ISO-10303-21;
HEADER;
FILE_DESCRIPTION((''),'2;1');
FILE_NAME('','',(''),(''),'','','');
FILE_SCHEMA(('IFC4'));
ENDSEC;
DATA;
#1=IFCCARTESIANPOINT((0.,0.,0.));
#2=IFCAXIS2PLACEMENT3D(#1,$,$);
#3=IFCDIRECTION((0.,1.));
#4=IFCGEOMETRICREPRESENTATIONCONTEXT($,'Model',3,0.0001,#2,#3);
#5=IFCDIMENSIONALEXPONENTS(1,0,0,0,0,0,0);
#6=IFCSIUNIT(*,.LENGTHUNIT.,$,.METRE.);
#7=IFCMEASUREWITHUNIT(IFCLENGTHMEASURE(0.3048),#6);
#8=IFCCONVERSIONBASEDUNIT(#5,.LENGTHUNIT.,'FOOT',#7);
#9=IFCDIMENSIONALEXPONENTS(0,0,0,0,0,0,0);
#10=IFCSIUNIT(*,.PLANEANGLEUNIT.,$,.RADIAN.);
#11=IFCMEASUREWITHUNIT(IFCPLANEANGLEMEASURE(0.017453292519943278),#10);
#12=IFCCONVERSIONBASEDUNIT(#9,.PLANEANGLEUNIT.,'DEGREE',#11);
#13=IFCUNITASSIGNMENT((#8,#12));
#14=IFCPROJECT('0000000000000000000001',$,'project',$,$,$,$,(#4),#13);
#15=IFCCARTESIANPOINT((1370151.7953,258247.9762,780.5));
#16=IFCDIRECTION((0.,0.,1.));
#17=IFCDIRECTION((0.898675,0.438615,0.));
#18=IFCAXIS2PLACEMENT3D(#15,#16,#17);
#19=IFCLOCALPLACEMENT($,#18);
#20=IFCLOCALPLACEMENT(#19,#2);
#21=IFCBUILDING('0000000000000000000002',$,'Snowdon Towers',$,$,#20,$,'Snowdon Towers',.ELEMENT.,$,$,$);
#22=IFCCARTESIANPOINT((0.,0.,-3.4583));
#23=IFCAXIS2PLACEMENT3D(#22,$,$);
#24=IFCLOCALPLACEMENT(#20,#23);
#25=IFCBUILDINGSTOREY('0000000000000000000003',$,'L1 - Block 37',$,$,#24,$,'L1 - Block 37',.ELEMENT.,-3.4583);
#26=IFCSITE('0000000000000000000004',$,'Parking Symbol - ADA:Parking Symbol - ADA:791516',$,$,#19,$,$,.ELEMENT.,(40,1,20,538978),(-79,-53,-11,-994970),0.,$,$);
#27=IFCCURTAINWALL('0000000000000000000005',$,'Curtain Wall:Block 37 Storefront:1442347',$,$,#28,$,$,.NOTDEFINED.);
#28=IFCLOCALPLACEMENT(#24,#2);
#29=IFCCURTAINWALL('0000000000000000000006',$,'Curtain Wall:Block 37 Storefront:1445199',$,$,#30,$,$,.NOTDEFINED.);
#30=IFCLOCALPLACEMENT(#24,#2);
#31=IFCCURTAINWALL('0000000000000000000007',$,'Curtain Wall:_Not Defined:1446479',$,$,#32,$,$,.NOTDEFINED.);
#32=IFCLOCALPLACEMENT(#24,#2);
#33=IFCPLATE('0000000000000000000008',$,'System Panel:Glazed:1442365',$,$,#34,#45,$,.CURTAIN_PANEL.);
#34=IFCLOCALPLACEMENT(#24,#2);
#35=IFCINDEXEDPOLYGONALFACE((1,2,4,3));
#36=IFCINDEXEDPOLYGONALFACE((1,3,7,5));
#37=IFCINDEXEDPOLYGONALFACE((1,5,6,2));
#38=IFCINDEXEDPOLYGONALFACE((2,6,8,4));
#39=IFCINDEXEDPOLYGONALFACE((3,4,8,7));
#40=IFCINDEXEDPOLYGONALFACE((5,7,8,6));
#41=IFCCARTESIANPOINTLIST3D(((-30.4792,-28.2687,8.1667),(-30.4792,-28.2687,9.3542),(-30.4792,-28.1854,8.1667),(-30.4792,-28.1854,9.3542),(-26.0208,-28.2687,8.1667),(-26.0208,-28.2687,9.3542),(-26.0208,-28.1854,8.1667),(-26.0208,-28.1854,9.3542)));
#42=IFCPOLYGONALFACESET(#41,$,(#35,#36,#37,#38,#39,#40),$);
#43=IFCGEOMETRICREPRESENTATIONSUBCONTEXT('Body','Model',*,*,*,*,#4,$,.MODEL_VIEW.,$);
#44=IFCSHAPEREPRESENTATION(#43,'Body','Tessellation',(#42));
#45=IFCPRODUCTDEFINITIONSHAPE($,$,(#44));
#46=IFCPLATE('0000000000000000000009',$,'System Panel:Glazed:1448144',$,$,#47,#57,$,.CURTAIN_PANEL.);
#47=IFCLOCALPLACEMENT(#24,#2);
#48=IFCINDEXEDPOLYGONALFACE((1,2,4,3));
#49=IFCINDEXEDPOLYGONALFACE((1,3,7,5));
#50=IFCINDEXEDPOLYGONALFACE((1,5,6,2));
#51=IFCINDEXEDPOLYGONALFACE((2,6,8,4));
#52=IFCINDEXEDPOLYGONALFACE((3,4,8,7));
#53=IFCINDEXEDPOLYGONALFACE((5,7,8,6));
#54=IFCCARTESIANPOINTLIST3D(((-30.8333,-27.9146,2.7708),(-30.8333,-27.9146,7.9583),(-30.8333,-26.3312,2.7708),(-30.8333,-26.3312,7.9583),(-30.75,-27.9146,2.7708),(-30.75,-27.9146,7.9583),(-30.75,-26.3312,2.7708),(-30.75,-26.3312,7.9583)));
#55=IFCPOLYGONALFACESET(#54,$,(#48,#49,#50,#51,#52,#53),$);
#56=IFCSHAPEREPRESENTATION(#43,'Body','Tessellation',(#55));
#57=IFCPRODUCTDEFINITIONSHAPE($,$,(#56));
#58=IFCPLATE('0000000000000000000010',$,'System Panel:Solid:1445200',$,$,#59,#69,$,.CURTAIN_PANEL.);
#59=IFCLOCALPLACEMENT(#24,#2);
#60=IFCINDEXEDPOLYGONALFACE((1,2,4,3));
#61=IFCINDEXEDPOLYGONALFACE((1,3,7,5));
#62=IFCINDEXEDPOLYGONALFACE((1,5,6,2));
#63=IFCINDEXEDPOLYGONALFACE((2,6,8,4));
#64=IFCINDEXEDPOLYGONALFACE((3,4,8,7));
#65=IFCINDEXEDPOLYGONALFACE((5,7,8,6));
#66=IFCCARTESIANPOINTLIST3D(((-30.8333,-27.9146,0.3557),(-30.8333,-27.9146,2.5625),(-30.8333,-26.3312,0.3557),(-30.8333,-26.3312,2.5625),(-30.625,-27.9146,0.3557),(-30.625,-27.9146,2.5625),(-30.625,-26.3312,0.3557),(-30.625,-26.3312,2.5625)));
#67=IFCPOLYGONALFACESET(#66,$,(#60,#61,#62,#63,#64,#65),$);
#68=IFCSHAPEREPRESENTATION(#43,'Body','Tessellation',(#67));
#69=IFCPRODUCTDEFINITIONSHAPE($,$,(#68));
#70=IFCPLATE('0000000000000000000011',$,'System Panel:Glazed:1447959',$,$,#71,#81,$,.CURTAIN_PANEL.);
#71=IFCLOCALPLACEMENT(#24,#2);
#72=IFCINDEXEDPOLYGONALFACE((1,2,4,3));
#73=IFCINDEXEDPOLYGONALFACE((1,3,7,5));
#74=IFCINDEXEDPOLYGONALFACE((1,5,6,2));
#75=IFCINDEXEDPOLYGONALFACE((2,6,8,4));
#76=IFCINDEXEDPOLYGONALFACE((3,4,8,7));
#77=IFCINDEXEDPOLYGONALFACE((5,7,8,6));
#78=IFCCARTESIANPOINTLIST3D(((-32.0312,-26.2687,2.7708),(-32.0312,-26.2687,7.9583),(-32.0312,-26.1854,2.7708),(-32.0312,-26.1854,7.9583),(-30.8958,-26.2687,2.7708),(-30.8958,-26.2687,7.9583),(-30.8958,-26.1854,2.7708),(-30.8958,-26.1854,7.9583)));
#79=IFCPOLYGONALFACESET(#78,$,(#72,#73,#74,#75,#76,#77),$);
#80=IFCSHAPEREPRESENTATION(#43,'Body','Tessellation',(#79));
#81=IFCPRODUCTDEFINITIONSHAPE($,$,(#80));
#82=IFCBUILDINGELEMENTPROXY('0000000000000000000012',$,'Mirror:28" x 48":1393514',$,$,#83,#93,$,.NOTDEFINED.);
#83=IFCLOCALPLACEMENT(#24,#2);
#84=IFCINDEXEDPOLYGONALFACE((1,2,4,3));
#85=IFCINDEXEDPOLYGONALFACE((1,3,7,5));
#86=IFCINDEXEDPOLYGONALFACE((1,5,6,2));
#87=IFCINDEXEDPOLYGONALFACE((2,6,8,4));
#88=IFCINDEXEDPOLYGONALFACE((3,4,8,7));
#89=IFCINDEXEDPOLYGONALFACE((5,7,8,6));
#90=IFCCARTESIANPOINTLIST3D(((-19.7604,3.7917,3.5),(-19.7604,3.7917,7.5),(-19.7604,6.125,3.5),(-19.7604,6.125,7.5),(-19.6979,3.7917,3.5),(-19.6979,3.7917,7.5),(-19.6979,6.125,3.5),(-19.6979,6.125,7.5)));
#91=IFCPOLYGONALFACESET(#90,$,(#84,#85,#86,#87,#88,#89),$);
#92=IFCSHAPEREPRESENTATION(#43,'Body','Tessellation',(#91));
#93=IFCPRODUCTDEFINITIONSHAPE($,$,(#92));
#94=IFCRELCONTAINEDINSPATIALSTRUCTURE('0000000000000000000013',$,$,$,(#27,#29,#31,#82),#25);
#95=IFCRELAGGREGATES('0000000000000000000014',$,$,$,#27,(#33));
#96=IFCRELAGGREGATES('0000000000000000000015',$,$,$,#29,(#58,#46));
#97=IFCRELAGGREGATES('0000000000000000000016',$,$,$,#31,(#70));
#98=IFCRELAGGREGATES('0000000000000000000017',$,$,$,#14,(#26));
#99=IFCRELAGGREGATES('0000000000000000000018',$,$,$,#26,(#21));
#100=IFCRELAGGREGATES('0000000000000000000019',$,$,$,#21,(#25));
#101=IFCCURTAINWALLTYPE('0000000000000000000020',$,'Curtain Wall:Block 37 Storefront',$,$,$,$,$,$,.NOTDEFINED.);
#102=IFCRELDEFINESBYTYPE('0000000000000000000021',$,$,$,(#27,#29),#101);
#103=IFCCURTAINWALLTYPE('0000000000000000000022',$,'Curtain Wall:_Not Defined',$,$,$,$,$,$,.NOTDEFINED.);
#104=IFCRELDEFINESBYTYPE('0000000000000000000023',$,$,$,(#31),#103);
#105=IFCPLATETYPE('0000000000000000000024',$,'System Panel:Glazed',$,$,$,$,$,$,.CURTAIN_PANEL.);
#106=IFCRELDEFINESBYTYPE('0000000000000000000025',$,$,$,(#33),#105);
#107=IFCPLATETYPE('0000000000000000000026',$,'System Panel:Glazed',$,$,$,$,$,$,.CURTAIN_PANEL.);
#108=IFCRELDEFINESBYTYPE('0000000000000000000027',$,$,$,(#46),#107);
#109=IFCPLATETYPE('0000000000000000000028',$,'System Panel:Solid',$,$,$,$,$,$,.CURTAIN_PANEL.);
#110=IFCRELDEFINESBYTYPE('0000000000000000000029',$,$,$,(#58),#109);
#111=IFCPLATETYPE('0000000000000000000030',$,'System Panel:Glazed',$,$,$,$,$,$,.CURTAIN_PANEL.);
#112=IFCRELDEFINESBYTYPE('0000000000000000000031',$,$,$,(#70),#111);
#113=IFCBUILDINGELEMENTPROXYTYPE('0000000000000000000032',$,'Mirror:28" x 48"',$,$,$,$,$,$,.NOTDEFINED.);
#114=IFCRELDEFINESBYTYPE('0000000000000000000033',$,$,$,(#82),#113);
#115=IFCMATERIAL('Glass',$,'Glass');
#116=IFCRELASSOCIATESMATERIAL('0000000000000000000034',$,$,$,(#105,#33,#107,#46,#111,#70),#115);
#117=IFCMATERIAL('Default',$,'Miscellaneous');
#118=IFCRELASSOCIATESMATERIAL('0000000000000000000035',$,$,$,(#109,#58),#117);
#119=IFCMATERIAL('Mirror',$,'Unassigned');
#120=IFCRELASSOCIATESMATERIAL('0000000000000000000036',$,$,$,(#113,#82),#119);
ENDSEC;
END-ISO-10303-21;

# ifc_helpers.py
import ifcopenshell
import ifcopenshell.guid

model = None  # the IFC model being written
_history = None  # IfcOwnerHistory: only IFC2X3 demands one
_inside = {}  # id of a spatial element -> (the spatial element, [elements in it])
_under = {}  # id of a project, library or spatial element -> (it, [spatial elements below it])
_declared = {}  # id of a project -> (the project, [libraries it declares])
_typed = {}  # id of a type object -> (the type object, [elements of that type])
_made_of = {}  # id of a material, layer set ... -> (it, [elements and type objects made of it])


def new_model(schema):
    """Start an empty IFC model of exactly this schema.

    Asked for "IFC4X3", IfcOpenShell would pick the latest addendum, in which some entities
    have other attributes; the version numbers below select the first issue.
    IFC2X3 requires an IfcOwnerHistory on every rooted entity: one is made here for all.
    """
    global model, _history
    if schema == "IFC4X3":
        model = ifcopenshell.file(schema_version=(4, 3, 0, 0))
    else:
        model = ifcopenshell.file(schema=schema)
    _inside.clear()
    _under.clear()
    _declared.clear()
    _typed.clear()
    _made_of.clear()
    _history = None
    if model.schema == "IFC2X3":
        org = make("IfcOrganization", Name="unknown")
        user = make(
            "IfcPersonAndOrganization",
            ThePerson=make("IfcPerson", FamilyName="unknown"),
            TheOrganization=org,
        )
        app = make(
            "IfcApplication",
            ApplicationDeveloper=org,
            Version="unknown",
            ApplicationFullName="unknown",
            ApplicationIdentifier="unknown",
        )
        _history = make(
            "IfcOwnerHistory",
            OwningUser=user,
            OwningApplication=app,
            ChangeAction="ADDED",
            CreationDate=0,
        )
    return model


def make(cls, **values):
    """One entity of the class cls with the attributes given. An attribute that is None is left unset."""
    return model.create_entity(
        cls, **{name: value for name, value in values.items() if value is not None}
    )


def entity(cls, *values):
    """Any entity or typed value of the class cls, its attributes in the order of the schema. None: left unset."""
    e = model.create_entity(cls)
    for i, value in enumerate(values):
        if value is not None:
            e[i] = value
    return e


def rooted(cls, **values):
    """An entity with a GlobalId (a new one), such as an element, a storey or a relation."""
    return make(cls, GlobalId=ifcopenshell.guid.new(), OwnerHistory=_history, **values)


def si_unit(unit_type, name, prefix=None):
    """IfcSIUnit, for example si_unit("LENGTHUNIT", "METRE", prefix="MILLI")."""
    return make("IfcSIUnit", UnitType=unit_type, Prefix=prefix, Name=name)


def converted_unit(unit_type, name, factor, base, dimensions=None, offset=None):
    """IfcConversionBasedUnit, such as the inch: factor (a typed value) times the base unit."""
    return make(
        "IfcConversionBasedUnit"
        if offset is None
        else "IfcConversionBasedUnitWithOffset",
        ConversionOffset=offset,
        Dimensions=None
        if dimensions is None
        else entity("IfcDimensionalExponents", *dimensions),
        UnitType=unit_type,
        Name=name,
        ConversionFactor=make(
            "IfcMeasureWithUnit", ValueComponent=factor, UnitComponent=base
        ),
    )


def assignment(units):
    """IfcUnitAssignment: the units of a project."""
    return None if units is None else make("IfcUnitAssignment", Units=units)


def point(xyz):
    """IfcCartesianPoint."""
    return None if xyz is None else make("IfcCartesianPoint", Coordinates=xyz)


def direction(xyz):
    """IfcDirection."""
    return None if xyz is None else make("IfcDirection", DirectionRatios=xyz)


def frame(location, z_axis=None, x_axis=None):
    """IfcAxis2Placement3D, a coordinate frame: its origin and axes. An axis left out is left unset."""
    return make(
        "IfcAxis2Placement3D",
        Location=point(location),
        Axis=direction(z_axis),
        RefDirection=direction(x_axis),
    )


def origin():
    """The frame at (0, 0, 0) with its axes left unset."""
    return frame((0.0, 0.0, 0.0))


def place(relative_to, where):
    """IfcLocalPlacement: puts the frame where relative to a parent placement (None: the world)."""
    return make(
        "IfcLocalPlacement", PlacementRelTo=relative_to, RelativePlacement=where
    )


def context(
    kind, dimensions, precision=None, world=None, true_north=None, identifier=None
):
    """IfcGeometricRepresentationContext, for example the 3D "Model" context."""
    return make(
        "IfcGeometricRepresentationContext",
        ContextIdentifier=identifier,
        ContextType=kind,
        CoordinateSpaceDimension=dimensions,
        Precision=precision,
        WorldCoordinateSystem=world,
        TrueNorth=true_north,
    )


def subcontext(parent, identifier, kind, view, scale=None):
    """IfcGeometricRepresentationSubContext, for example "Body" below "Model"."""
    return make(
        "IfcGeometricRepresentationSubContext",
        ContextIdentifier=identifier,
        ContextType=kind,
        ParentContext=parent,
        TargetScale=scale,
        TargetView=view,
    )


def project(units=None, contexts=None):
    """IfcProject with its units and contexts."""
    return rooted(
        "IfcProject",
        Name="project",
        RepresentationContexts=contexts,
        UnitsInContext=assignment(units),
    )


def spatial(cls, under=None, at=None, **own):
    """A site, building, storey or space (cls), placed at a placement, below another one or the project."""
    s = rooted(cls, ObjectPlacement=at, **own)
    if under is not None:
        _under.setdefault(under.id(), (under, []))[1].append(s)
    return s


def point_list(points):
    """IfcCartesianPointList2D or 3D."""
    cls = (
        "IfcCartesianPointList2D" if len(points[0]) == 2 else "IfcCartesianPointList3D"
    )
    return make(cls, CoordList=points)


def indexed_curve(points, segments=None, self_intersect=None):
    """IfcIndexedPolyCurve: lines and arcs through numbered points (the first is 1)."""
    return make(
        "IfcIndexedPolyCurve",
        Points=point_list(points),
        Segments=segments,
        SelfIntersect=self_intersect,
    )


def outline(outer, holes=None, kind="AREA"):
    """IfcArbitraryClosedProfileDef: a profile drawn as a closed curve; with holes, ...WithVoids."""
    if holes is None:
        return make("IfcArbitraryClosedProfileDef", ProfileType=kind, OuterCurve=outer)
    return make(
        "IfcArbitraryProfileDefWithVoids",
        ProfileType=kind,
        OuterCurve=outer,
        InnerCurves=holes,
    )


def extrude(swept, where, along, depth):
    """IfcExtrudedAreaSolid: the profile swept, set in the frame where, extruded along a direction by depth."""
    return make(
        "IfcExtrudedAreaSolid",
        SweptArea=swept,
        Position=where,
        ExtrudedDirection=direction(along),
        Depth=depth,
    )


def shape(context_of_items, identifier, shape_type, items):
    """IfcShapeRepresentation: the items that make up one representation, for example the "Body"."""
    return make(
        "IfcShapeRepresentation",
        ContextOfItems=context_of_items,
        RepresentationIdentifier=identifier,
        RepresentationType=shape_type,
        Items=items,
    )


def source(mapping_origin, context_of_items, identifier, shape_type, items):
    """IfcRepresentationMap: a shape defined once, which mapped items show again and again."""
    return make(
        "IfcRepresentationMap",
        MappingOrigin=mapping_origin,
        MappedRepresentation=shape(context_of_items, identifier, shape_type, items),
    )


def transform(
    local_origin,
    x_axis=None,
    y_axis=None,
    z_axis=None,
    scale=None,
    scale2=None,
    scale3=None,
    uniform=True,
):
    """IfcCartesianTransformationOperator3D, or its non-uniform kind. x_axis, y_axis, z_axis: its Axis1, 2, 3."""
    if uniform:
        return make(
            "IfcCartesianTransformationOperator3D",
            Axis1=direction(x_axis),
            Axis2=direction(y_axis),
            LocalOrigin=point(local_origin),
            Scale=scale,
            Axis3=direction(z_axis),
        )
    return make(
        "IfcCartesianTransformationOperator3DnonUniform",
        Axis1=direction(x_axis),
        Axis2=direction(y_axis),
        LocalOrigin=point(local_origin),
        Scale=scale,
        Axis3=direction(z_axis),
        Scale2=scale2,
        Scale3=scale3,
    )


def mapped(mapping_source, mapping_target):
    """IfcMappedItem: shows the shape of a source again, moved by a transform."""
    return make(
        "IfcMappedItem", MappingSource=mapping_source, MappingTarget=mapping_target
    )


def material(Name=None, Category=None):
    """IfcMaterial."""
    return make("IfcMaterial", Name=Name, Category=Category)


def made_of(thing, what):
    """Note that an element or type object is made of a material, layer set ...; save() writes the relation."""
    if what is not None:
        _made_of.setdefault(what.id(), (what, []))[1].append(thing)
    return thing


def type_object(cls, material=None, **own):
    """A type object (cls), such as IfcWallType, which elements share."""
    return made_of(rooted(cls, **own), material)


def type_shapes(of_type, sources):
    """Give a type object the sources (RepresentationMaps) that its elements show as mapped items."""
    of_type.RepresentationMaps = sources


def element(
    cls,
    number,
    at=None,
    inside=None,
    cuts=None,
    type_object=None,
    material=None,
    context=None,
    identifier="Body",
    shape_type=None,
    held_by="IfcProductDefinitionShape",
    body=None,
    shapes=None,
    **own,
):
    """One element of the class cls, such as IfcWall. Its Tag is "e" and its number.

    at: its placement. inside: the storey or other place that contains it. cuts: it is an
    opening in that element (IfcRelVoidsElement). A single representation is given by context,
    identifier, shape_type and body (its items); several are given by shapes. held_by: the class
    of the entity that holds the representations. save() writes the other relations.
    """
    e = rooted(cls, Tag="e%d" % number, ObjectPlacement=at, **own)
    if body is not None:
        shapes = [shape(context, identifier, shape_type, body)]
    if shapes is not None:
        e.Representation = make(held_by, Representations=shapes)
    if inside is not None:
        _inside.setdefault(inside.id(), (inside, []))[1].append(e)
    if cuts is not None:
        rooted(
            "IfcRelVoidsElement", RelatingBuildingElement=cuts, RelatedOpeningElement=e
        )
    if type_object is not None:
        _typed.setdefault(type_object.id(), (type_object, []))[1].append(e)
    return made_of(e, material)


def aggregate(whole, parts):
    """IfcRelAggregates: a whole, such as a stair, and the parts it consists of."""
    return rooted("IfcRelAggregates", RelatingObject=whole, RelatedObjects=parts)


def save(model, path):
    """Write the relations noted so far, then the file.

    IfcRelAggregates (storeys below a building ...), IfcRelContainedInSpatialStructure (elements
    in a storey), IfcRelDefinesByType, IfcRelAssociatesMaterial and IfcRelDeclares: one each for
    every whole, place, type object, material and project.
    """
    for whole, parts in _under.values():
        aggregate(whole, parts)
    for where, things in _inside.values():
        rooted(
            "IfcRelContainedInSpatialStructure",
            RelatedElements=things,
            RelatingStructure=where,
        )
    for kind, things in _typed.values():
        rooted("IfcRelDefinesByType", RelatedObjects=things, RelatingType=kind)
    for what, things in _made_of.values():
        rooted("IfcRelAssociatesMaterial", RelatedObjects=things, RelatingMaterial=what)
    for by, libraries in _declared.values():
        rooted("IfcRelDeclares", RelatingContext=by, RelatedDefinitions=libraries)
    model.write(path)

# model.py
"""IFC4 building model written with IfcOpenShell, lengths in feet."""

from ifc_helpers import new_model, entity, si_unit, converted_unit, direction, frame, origin, place, context, subcontext, project, spatial, indexed_curve, outline, extrude, source, transform, mapped, material, type_object, type_shapes, element, aggregate, save


model = new_model("IFC4")

# Units and contexts
model_context = context("Model", 3, precision=0.0001, world=origin(), true_north=direction((0.0, 1.0)))
body_context = subcontext(model_context, "Body", "Model", "MODEL_VIEW")
ifc_project = project(units=[converted_unit("LENGTHUNIT", "FOOT", entity("IfcLengthMeasure", 0.3048), si_unit("LENGTHUNIT", "METRE"), dimensions=[1, 0, 0, 0, 0, 0, 0]), converted_unit("PLANEANGLEUNIT", "DEGREE", entity("IfcPlaneAngleMeasure", 0.017453292519943278), si_unit("PLANEANGLEUNIT", "RADIAN"), dimensions=[0, 0, 0, 0, 0, 0, 0])], contexts=[model_context])

# Site, building, storey
site_placement = place(None, frame((1370151.7953, 258247.9762, 780.5), z_axis=(0.0, 0.0, 1.0), x_axis=(0.898675, 0.438615, 0.0)))
site = spatial("IfcSite", under=ifc_project, at=site_placement, Name="Parking Symbol - ADA:Parking Symbol - ADA:791516", CompositionType="ELEMENT", RefLatitude=(40, 1, 20, 538978), RefLongitude=(-79, -53, -11, -994970), RefElevation=0.0)
building_placement = place(site_placement, origin())
building = spatial("IfcBuilding", under=site, at=building_placement, Name="Snowdon Towers", LongName="Snowdon Towers", CompositionType="ELEMENT")
storey_placement = place(building_placement, frame((0.0, 0.0, -3.4583)))
storey = spatial("IfcBuildingStorey", under=building, at=storey_placement, Name="L1 - Block 37", LongName="L1 - Block 37", CompositionType="ELEMENT", Elevation=-3.4583)

# Curtain walls
curtain_wall_type_1 = type_object("IfcCurtainWallType", Name="Curtain Wall:Block 37 Storefront", PredefinedType="NOTDEFINED")
curtain_wall_1_placement = place(storey_placement, frame((0.0, 0.0, 3.4583)))
curtain_wall_1 = element("IfcCurtainWall", 1, at=curtain_wall_1_placement, inside=storey, type_object=curtain_wall_type_1, Name="Curtain Wall:Block 37 Storefront:1442347", PredefinedType="NOTDEFINED")
curtain_wall_2_placement = place(storey_placement, frame((0.0, 0.0, 3.4583)))
curtain_wall_2 = element("IfcCurtainWall", 2, at=curtain_wall_2_placement, inside=storey, type_object=curtain_wall_type_1, Name="Curtain Wall:Block 37 Storefront:1445199", PredefinedType="NOTDEFINED")
curtain_wall_type_2 = type_object("IfcCurtainWallType", Name="Curtain Wall:_Not Defined", PredefinedType="NOTDEFINED")
curtain_wall_3_placement = place(storey_placement, frame((0.0, 0.0, 3.4583)))
curtain_wall_3 = element("IfcCurtainWall", 3, at=curtain_wall_3_placement, inside=storey, type_object=curtain_wall_type_2, Name="Curtain Wall:_Not Defined:1446479", PredefinedType="NOTDEFINED")

# Plates
ifc_material_1 = material(Name="Default", Category="Miscellaneous")
ifc_material_2 = material(Name="Glass", Category="Glass")
plate_type_1 = type_object("IfcPlateType", Name="System Panel:Glazed", PredefinedType="CURTAIN_PANEL", material=ifc_material_2)
shared_shape_1 = source(origin(), body_context, "Body", "SweptSolid", [
    extrude(outline(indexed_curve([(-0.0417, -2.2292), (0.0417, -2.2292), (0.0417, 2.2292), (-0.0417, 2.2292), (-0.0417, -2.2292)], self_intersect=False)), frame((0.0, -0.1042, 0.0), z_axis=(0.0, 0.0, 1.0), x_axis=(0.0, 1.0, 0.0)), (0.0, 0.0, 1.0), 1.1875),
])
type_shapes(plate_type_1, [shared_shape_1])
plate_1_placement = place(curtain_wall_1_placement, frame((-28.25, -28.1229, 4.7083)))
plate_1 = element("IfcPlate", 4, at=plate_1_placement, type_object=plate_type_1, material=ifc_material_2, Name="System Panel:Glazed:1442365", PredefinedType="CURTAIN_PANEL", context=body_context, shape_type="MappedRepresentation", body=[
    mapped(shared_shape_1, transform((0.0, 0.0, 0.0), scale=1.0)),
])
aggregate(curtain_wall_1, [plate_1])
plate_type_2 = type_object("IfcPlateType", Name="System Panel:Glazed", PredefinedType="CURTAIN_PANEL", material=ifc_material_2)
shared_shape_2 = source(origin(), body_context, "Body", "SweptSolid", [
    extrude(outline(indexed_curve([(-0.0417, -0.7917), (0.0417, -0.7917), (0.0417, 0.7917), (-0.0417, 0.7917), (-0.0417, -0.7917)], self_intersect=False)), frame((0.0, -0.1042, 0.0), z_axis=(0.0, 0.0, 1.0), x_axis=(0.0, 1.0, 0.0)), (0.0, 0.0, 1.0), 5.1875),
])
type_shapes(plate_type_2, [shared_shape_2])
plate_2_placement = place(curtain_wall_2_placement, frame((-30.6875, -27.1229, -0.6875), z_axis=(0.0, 0.0, 1.0), x_axis=(0.0, -1.0, 0.0)))
plate_2 = element("IfcPlate", 5, at=plate_2_placement, type_object=plate_type_2, material=ifc_material_2, Name="System Panel:Glazed:1448144", PredefinedType="CURTAIN_PANEL", context=body_context, shape_type="MappedRepresentation", body=[
    mapped(shared_shape_2, transform((0.0, 0.0, 0.0), scale=1.0)),
])
plate_type_3 = type_object("IfcPlateType", Name="System Panel:Solid", PredefinedType="CURTAIN_PANEL", material=ifc_material_1)
shared_shape_3 = source(origin(), body_context, "Body", "SweptSolid", [
    extrude(outline(indexed_curve([(-0.1042, -0.7917), (0.1042, -0.7917), (0.1042, 0.7917), (-0.1042, 0.7917), (-0.1042, -0.7917)], self_intersect=False)), frame((0.0, -0.0417, 0.0), z_axis=(0.0, 0.0, 1.0), x_axis=(0.0, 1.0, 0.0)), (0.0, 0.0, 1.0), 2.2068),
])
type_shapes(plate_type_3, [shared_shape_3])
plate_3_placement = place(curtain_wall_2_placement, frame((-30.6875, -27.1229, -3.1027), z_axis=(0.0, 0.0, 1.0), x_axis=(0.0, -1.0, 0.0)))
plate_3 = element("IfcPlate", 6, at=plate_3_placement, type_object=plate_type_3, material=ifc_material_1, Name="System Panel:Solid:1445200", PredefinedType="CURTAIN_PANEL", context=body_context, shape_type="MappedRepresentation", body=[
    mapped(shared_shape_3, transform((0.0, 0.0, 0.0), scale=1.0)),
])
aggregate(curtain_wall_2, [plate_3, plate_2])
plate_type_4 = type_object("IfcPlateType", Name="System Panel:Glazed", PredefinedType="CURTAIN_PANEL", material=ifc_material_2)
shared_shape_4 = source(origin(), body_context, "Body", "SweptSolid", [
    extrude(outline(indexed_curve([(-0.0417, -0.5677), (0.0417, -0.5677), (0.0417, 0.5677), (-0.0417, 0.5677), (-0.0417, -0.5677)], self_intersect=False)), frame((0.0, -0.1042, 0.0), z_axis=(0.0, 0.0, 1.0), x_axis=(0.0, 1.0, 0.0)), (0.0, 0.0, 1.0), 5.1875),
])
type_shapes(plate_type_4, [shared_shape_4])
plate_4_placement = place(curtain_wall_3_placement, frame((-31.4635, -26.1229, -0.6875)))
plate_4 = element("IfcPlate", 7, at=plate_4_placement, type_object=plate_type_4, material=ifc_material_2, Name="System Panel:Glazed:1447959", PredefinedType="CURTAIN_PANEL", context=body_context, shape_type="MappedRepresentation", body=[
    mapped(shared_shape_4, transform((0.0, 0.0, 0.0), scale=1.0)),
])
aggregate(curtain_wall_3, [plate_4])

# Building element proxy
ifc_material_3 = material(Name="Mirror", Category="Unassigned")
building_element_proxy_type = type_object("IfcBuildingElementProxyType", Name="Mirror:28\" x 48\"", PredefinedType="NOTDEFINED", material=ifc_material_3)
shared_shape_5 = source(origin(), body_context, "Body", "SweptSolid", [
    extrude(outline(indexed_curve([(-1.1667, -0.0312), (1.1667, -0.0312), (1.1667, 0.0312), (-1.1667, 0.0312), (-1.1667, -0.0312)], self_intersect=False)), frame((0.0803, -0.5208, 3.5)), (0.0, 0.0, 1.0), 4.0),
])
type_shapes(building_element_proxy_type, [shared_shape_5])
proxy_placement = place(storey_placement, frame((-20.25, 4.8781, 0.0), z_axis=(0.0, 0.0, 1.0), x_axis=(0.0, 1.0, 0.0)))
element("IfcBuildingElementProxy", 8, at=proxy_placement, inside=storey, type_object=building_element_proxy_type, material=ifc_material_3, Name="Mirror:28\" x 48\":1393514", PredefinedType="NOTDEFINED", context=body_context, shape_type="MappedRepresentation", body=[
    mapped(shared_shape_5, transform((0.0, 0.0, 0.0), scale=1.0)),
])

save(model, "model.ifc")
